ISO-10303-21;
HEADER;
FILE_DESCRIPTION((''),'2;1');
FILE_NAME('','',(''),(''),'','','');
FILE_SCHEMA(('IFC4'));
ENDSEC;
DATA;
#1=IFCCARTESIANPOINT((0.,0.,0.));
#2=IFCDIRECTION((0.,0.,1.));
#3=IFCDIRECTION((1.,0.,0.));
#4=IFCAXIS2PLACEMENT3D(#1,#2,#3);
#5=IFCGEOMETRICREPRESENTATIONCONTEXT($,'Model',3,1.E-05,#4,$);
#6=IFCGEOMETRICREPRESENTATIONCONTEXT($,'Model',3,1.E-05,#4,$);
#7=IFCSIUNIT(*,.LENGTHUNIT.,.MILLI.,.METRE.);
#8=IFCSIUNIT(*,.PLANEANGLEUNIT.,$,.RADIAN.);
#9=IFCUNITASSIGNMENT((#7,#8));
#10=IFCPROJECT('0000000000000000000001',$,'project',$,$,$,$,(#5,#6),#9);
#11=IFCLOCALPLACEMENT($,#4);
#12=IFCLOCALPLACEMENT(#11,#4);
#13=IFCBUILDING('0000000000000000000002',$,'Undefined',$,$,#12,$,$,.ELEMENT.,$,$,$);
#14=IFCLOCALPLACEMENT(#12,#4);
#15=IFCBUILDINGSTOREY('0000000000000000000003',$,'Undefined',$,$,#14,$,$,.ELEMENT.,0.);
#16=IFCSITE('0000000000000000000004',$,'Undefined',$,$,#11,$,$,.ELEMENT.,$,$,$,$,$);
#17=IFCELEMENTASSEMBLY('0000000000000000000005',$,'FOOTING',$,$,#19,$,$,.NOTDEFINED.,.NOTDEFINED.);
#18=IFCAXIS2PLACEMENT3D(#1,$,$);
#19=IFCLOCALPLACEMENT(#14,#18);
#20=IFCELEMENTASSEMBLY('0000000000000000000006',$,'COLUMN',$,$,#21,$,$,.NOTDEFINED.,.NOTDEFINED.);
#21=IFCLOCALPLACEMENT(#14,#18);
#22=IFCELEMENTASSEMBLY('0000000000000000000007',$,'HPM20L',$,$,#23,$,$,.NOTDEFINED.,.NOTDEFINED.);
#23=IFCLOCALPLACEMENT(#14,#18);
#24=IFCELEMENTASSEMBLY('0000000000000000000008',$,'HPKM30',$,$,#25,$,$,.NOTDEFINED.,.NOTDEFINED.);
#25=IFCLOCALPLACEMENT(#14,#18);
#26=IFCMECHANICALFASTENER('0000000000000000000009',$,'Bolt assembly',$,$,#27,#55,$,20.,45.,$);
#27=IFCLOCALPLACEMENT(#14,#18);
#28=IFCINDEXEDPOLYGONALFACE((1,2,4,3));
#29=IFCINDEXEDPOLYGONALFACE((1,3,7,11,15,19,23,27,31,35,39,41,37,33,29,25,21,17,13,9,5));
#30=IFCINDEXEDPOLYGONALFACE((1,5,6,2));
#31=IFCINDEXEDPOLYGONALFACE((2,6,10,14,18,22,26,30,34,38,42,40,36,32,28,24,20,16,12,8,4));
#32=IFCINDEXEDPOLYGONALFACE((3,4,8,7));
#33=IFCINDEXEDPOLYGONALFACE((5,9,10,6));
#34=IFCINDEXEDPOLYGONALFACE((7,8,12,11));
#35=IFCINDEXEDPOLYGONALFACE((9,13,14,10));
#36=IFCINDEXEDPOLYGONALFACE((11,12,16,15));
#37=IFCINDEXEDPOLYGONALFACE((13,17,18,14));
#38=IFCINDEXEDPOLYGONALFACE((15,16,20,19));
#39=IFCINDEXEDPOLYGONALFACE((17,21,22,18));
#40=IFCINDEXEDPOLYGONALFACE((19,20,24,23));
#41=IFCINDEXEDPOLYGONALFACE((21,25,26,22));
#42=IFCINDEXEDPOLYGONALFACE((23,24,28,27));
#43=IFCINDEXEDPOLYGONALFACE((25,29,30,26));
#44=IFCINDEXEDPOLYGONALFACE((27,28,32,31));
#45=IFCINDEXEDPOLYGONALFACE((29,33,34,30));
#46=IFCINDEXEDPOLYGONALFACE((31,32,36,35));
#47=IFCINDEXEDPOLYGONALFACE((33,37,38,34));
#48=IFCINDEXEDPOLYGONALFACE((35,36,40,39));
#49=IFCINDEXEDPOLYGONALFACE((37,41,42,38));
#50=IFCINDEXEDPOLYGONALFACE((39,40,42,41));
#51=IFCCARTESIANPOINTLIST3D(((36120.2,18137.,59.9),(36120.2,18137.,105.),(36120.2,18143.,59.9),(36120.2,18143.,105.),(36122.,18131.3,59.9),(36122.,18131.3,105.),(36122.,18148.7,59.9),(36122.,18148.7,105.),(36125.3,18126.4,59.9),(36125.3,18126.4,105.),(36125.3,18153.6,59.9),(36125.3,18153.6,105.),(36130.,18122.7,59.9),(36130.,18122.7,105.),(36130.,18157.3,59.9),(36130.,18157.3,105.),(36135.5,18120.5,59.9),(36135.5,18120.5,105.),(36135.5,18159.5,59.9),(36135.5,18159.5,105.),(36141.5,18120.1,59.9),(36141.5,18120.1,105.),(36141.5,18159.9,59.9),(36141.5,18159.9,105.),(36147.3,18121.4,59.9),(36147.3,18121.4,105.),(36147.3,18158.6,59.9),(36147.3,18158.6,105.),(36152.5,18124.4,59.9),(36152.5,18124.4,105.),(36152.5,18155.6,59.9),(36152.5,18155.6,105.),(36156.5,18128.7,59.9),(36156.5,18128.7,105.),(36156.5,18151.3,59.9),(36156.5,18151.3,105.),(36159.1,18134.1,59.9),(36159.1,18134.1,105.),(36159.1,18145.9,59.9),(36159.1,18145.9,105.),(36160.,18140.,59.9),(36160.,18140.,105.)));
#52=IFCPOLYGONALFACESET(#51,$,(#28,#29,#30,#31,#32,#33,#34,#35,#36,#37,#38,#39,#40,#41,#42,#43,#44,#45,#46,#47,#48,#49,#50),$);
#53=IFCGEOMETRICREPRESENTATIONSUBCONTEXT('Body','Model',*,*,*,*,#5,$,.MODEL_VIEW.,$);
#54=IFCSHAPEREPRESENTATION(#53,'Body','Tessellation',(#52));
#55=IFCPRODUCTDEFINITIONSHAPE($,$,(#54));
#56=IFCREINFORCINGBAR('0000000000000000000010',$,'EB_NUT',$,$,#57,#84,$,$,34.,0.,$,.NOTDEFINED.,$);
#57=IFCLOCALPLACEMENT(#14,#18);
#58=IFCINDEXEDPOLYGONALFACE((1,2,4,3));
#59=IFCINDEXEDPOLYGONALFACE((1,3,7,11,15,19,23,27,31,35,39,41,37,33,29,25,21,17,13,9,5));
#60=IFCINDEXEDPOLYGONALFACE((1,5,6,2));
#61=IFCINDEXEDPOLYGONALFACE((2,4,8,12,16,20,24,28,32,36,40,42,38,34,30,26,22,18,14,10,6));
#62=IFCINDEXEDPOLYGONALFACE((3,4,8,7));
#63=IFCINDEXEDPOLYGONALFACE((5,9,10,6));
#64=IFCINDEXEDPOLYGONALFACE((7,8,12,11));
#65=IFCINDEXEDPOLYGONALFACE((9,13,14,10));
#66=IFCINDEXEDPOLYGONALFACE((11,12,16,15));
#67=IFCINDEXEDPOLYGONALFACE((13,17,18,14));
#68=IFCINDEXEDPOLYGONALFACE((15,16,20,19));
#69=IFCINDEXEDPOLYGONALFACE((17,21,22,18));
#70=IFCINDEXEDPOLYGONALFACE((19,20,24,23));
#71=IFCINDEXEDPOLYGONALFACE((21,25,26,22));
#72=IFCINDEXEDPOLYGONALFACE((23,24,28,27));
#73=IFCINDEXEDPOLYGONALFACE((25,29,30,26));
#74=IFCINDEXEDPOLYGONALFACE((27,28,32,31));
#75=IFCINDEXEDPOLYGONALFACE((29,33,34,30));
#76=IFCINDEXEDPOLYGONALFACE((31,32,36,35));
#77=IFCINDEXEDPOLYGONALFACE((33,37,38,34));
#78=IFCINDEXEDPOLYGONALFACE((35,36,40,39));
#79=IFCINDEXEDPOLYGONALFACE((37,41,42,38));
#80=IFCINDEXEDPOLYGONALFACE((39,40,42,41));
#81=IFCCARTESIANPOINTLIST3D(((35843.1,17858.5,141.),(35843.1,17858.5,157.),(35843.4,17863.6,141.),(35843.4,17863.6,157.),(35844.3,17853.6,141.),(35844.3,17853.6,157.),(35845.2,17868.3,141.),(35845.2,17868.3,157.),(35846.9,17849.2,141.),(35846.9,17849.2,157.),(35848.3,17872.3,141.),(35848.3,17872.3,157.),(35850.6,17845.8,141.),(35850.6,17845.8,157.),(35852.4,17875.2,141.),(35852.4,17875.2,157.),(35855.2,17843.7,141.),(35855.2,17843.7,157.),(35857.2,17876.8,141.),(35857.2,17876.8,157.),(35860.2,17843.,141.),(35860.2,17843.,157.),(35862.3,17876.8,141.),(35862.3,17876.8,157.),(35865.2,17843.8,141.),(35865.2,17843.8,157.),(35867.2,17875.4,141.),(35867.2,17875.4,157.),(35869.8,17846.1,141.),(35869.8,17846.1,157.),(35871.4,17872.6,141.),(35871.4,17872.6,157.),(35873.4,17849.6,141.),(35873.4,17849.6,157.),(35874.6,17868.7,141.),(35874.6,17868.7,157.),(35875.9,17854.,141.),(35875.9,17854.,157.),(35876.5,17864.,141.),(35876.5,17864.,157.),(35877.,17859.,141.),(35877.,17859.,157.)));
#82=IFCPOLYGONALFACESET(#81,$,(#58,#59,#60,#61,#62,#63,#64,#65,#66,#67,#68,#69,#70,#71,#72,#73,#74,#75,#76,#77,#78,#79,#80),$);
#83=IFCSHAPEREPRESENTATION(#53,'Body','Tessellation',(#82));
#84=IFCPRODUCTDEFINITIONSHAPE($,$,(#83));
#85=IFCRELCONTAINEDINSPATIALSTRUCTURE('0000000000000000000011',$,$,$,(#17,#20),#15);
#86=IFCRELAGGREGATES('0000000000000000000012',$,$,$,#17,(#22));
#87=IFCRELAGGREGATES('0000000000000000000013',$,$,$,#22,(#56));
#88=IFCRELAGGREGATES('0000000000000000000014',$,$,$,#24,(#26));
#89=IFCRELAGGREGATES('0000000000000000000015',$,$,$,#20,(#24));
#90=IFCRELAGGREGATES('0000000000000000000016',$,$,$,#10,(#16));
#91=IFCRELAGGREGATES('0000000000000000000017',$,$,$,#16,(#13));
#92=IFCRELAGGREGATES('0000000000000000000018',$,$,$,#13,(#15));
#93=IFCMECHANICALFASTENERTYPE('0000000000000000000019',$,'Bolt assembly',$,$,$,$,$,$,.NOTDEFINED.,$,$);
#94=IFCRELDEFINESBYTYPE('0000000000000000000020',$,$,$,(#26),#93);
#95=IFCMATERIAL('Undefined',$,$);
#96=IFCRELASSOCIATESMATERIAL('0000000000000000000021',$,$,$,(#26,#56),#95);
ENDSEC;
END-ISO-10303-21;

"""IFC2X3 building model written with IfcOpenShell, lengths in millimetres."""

from ifc_helpers import new_model, entity, si_unit, frame, origin_with_axes, origin_2d_with_axis, place, context, subcontext, project, spatial, circle, extrude, source, transform, mapped, material, type_object, element, aggregate, save


model = new_model("IFC2X3")

# Units and contexts
model_context_1 = context("Model", 3, precision=1e-05, world=origin_with_axes())
model_context_2 = context("Model", 3, precision=1e-05, world=origin_with_axes())
body_context = subcontext(model_context_1, "Body", "Model", "MODEL_VIEW")
ifc_project = project(units=[si_unit("LENGTHUNIT", "METRE", prefix="MILLI"), si_unit("PLANEANGLEUNIT", "RADIAN")], contexts=[model_context_1, model_context_2])

# Site, building, storey
site_placement = place(None, origin_with_axes())
site = spatial("IfcSite", under=ifc_project, at=site_placement, Name="Undefined", CompositionType="ELEMENT")
building_placement = place(site_placement, origin_with_axes())
building = spatial("IfcBuilding", under=site, at=building_placement, Name="Undefined", CompositionType="ELEMENT")
storey_placement = place(building_placement, origin_with_axes())
storey = spatial("IfcBuildingStorey", under=building, at=storey_placement, Name="Undefined", CompositionType="ELEMENT", Elevation=0.0)

# Element assembly
assembly_1_placement = place(storey_placement, origin_with_axes())
assembly_1 = element("IfcElementAssembly", 1, at=assembly_1_placement, inside=storey, Name="FOOTING", AssemblyPlace="NOTDEFINED", PredefinedType="NOTDEFINED")

# Element assembly
assembly_2_placement = place(storey_placement, origin_with_axes())
assembly_2 = element("IfcElementAssembly", 2, at=assembly_2_placement, inside=storey, Name="COLUMN", AssemblyPlace="NOTDEFINED", PredefinedType="NOTDEFINED")

# Element assembly
assembly_3_placement = place(assembly_1_placement, origin_with_axes())
assembly_3 = element("IfcElementAssembly", 3, at=assembly_3_placement, Name="HPM20L", AssemblyPlace="NOTDEFINED", PredefinedType="NOTDEFINED")

aggregate(assembly_1, [assembly_3])

# Element assembly
assembly_4_placement = place(assembly_2_placement, origin_with_axes())
assembly_4 = element("IfcElementAssembly", 4, at=assembly_4_placement, Name="HPKM30", AssemblyPlace="NOTDEFINED", PredefinedType="NOTDEFINED")

# Mechanical fastener
ifc_material_1 = material(Name="Undefined")
mechanical_fastener_type = type_object("IfcMechanicalFastenerType", Name="Bolt assembly")
shared_shape_1 = source(origin_with_axes(), body_context, "Body", "SweptSolid", [
    extrude(circle(Radius=20.0, at=origin_2d_with_axis()), frame((0.0, -45.0, 0.0), z_axis=(0.0, 1.0, 0.0), x_axis=(1.0, 0.0, 0.0)), (0.0, 0.0, 1.0), 45.1),
])
mechanical_fastener_1_placement = place(assembly_4_placement, frame((36140.0, 18140.0, 60.0), z_axis=(0.0, 1.0, 0.0), x_axis=(1.0, 0.0, 0.0)))
mechanical_fastener_1 = element("IfcMechanicalFastener", 5, at=mechanical_fastener_1_placement, type_object=mechanical_fastener_type, material=ifc_material_1, Name="Bolt assembly", NominalDiameter=20.0, NominalLength=45.0, context=body_context, shape_type="MappedRepresentation", body=[
    mapped(shared_shape_1, transform((0.0, 0.0, 0.0))),
])

# Reinforcing bar
shared_shape_2 = source(origin_with_axes(), body_context, "Body", "AdvancedSweptSolid", [
    entity("IfcSweptDiskSolid", entity("IfcTrimmedCurve", entity("IfcLine", entity("IfcCartesianPoint", [0.0, 0.0, 0.0]), entity("IfcVector", entity("IfcDirection", [1.0, 0.0, 0.0]), 1.0)), [entity("IfcParameterValue", 0.0)], [entity("IfcParameterValue", 16.0)], True, "PARAMETER"), 17.0, None, 0.0, 16.0),
])
reinforcing_bar_1_placement = place(assembly_3_placement, frame((35860.0, 17860.0, 157.0), z_axis=(-0.445815, 0.895125, 0.0), x_axis=(0.0, 0.0, -1.0)))
reinforcing_bar_1 = element("IfcReinforcingBar", 6, at=reinforcing_bar_1_placement, material=ifc_material_1, Name="EB_NUT", BarRole="NOTDEFINED", CrossSectionArea=0.0, NominalDiameter=34.0, context=body_context, shape_type="MappedRepresentation", body=[
    mapped(shared_shape_2, transform((0.0, 0.0, 0.0))),
])
aggregate(assembly_3, [reinforcing_bar_1])
aggregate(assembly_4, [mechanical_fastener_1])
aggregate(assembly_2, [assembly_4])

save(model, "model.ifc")
